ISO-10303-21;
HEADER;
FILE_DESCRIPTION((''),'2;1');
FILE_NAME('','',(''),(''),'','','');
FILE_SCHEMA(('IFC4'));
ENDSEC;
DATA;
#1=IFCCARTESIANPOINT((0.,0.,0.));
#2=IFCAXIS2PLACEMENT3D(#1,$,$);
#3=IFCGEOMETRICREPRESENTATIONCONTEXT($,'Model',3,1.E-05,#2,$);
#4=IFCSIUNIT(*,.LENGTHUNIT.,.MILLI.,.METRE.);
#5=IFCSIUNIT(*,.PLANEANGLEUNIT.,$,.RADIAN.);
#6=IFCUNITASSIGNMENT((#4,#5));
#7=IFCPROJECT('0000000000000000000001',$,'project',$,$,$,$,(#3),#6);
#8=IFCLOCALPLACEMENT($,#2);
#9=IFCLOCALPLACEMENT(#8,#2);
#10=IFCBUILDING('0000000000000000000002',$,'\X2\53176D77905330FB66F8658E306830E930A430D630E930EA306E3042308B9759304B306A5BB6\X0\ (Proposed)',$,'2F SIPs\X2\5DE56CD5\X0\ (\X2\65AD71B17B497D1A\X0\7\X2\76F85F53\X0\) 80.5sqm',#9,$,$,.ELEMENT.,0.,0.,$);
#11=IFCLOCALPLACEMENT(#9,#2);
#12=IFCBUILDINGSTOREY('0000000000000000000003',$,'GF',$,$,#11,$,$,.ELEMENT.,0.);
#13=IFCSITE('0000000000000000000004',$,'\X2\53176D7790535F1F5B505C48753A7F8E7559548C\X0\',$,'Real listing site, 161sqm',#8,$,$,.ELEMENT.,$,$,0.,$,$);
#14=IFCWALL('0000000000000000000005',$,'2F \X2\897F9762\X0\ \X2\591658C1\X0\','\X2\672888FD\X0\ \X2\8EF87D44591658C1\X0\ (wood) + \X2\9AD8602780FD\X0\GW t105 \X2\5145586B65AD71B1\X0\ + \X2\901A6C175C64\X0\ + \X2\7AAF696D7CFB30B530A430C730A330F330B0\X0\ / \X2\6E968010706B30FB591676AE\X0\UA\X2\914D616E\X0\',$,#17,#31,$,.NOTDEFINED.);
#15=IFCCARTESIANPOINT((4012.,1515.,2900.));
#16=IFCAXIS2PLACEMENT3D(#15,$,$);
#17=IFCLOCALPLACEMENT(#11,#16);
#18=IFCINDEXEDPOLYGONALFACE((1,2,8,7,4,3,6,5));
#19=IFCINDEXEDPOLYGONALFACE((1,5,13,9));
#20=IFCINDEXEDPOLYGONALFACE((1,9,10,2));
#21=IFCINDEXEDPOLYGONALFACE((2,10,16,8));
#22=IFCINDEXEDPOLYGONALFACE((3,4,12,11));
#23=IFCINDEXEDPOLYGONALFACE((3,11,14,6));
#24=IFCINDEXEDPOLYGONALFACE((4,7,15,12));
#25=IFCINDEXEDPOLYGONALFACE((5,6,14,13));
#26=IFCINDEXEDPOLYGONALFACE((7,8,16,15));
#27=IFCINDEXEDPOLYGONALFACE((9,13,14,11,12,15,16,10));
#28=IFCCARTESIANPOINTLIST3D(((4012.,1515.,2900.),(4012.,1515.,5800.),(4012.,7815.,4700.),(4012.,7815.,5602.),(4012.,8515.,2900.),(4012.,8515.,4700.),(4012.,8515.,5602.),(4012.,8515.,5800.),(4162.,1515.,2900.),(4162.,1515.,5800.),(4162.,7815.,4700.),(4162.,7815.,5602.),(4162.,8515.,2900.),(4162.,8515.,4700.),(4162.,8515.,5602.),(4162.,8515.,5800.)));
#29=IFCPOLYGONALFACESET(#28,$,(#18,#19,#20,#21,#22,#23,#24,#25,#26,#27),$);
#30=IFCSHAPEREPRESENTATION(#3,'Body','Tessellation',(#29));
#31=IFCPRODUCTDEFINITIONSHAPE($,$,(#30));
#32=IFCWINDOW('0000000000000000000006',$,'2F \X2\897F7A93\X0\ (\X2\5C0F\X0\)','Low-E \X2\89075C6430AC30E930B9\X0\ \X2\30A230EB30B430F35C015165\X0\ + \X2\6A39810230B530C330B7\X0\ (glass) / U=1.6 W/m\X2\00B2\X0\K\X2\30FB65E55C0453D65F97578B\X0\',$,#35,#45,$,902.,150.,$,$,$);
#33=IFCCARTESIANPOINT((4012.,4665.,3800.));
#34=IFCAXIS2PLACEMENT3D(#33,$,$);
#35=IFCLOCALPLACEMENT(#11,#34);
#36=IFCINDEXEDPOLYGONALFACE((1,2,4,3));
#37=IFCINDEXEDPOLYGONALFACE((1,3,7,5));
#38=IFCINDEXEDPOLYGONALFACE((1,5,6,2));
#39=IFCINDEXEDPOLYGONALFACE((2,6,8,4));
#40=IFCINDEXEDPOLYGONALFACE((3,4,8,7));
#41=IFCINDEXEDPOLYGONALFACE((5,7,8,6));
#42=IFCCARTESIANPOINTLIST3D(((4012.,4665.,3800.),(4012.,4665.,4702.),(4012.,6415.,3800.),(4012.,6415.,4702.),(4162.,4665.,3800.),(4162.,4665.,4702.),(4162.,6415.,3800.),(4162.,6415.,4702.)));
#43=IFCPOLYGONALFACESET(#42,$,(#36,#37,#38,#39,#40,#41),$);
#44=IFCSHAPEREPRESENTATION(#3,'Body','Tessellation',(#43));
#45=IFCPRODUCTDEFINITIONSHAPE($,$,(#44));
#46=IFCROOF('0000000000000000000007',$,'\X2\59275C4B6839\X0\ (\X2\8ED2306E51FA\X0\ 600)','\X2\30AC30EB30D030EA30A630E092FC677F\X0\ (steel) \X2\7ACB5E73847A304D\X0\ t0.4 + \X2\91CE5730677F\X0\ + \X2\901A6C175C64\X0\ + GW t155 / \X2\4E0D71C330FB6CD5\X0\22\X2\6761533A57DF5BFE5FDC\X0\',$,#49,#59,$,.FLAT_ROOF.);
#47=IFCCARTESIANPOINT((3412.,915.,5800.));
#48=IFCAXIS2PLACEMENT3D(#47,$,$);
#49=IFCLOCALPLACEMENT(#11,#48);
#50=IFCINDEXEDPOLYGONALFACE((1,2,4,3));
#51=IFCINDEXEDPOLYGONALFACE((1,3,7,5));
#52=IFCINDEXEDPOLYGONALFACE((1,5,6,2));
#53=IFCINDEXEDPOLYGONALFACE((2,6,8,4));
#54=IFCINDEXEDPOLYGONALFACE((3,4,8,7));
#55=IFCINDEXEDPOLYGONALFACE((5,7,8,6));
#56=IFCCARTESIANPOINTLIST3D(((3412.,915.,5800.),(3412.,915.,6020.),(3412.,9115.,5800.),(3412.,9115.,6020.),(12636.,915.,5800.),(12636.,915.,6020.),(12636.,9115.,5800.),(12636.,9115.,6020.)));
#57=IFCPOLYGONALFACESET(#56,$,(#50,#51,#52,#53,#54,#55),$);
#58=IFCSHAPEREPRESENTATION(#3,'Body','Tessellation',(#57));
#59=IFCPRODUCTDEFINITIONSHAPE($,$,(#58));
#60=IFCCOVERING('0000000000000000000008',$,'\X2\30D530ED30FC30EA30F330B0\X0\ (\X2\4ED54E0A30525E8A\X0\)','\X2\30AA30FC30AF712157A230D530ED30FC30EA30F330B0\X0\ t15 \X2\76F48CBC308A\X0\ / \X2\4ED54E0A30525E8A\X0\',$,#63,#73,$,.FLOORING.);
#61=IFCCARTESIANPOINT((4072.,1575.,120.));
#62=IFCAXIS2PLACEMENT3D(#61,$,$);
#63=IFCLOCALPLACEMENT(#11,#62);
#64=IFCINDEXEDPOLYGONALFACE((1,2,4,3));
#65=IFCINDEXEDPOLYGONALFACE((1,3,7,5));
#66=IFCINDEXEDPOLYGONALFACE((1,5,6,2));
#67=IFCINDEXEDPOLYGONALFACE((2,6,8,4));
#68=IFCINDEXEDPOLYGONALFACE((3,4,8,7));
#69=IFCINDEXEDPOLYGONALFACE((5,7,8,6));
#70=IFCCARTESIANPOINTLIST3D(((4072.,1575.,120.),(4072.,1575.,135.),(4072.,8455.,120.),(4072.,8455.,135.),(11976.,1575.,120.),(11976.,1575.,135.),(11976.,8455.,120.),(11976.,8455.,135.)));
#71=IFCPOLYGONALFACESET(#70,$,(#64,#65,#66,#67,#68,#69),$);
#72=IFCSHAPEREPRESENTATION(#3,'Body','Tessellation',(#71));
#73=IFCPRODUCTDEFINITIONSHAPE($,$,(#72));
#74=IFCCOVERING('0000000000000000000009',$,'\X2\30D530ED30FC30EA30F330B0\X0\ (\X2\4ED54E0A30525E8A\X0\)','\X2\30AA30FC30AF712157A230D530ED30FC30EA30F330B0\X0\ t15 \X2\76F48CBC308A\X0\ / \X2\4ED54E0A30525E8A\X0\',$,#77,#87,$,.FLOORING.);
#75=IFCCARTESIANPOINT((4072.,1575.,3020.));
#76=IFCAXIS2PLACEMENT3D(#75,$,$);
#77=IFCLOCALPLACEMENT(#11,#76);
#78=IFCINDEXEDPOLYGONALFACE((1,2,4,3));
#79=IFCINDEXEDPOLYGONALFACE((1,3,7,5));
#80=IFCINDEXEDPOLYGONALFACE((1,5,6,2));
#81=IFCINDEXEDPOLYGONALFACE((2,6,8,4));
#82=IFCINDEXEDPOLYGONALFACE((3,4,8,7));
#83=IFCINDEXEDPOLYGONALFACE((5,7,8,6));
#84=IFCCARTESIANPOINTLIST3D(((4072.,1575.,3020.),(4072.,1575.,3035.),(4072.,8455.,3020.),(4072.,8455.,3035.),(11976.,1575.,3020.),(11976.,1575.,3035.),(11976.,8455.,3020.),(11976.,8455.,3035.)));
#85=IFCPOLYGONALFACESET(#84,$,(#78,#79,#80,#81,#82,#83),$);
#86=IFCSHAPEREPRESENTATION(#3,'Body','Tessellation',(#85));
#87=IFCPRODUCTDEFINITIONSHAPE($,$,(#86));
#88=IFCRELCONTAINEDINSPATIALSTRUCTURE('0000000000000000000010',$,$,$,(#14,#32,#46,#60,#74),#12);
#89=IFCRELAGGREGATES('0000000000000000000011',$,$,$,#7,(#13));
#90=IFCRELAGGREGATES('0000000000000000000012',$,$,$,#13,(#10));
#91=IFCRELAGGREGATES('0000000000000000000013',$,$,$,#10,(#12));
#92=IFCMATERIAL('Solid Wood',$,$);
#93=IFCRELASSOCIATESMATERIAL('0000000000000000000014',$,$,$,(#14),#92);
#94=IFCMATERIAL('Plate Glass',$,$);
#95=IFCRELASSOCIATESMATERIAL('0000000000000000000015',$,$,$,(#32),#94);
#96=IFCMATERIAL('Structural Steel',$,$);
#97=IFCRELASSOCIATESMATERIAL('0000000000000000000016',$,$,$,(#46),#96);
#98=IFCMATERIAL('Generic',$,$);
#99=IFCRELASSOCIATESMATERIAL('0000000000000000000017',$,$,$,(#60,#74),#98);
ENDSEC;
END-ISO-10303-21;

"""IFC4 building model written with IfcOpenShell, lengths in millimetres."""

from ifc_helpers import new_model, si_unit, frame, frame_2d, origin, place, context, project, spatial, rectangle, extrude, material, element, fill, save


model = new_model("IFC4")

# Units and contexts
model_context = context("Model", 3, precision=1e-05, world=origin())
ifc_project = project(units=[si_unit("LENGTHUNIT", "METRE", prefix="MILLI"), si_unit("PLANEANGLEUNIT", "RADIAN")], contexts=[model_context])

# Site, building, storey
site_placement = place(None, origin())
site = spatial("IfcSite", under=ifc_project, at=site_placement, Name="北海道弟子屈町美留和", ObjectType="Real listing site, 161sqm", CompositionType="ELEMENT", RefElevation=0.0)
building_placement = place(site_placement, origin())
building = spatial("IfcBuilding", under=site, at=building_placement, Name="北海道・書斎とライブラリのある静かな家 (Proposed)", ObjectType="2F SIPs工法 (断熱等級7相当) 80.5sqm", CompositionType="ELEMENT", ElevationOfRefHeight=0.0, ElevationOfTerrain=0.0)
storey_placement = place(building_placement, origin())
storey = spatial("IfcBuildingStorey", under=building, at=storey_placement, Name="GF", CompositionType="ELEMENT", Elevation=0.0)

# Shared definitions
ifc_material_1 = material(Name="Solid Wood")

# Shared definitions
ifc_material_2 = material(Name="Plate Glass")

# Wall, opening, window
wall_1_placement = place(storey_placement, frame((4012.0, 1515.0, 2900.0)))
wall_1 = element("IfcWall", 1, at=wall_1_placement, inside=storey, material=ifc_material_1, Name="2F 西面 外壁", Description="木製 軸組外壁 (wood) + 高性能GW t105 充填断熱 + 通気層 + 窯業系サイディング / 準耐火・外皮UA配慮", PredefinedType="NOTDEFINED", context=model_context, shape_type="SweptSolid", body=[
    extrude(rectangle(XDim=150.0, YDim=7000.0, at=frame_2d((75.0, 3500.0))), frame((4012.0, 1515.0, 2900.0)), (0.0, 0.0, 1.0), 2900.0),
])
opening_1_placement = place(storey_placement, frame((4012.0, 4665.0, 3800.0)))
opening_1 = element("IfcOpeningElement", 2, at=opening_1_placement, cuts=wall_1, PredefinedType="NOTDEFINED", context=model_context, shape_type="SweptSolid", body=[
    extrude(rectangle(XDim=150.0, YDim=1750.0, at=frame_2d((75.0, 875.0))), frame((4012.0, 4665.0, 3800.0)), (0.0, 0.0, 1.0), 902.0),
])
window_1_placement = place(storey_placement, frame((4012.0, 4665.0, 3800.0)))
window_1 = element("IfcWindow", 3, at=window_1_placement, inside=storey, material=ifc_material_2, Name="2F 西窓 (小)", Description="Low-E 複層ガラス アルゴン封入 + 樹脂サッシ (glass) / U=1.6 W/m²K・日射取得型", OverallHeight=902.0, OverallWidth=150.0, context=model_context, shape_type="SweptSolid", body=[
    extrude(rectangle(XDim=150.0, YDim=1750.0, at=frame_2d((75.0, 875.0))), frame((4012.0, 4665.0, 3800.0)), (0.0, 0.0, 1.0), 902.0),
])
fill(opening_1, window_1)

# Roof
ifc_material_3 = material(Name="Structural Steel")
roof_placement = place(storey_placement, frame((3412.0, 915.0, 5800.0)))
element("IfcRoof", 4, at=roof_placement, inside=storey, material=ifc_material_3, Name="大屋根 (軒の出 600)", Description="ガルバリウム鋼板 (steel) 立平葺き t0.4 + 野地板 + 通気層 + GW t155 / 不燃・法22条区域対応", PredefinedType="FLAT_ROOF", context=model_context, shape_type="SweptSolid", body=[
    extrude(rectangle(XDim=9224.0, YDim=8200.0, at=frame_2d((4612.0, 4100.0))), frame((3412.0, 915.0, 5800.0)), (0.0, 0.0, 1.0), 220.0),
])

# Coverings
ifc_material_4 = material(Name="Generic")
covering_1_placement = place(storey_placement, frame((4072.0, 1575.0, 120.0)))
element("IfcCovering", 5, at=covering_1_placement, inside=storey, material=ifc_material_4, Name="フローリング (仕上げ床)", Description="オーク無垢フローリング t15 直貼り / 仕上げ床", PredefinedType="FLOORING", context=model_context, shape_type="SweptSolid", body=[
    extrude(rectangle(XDim=7904.0, YDim=6880.0, at=frame_2d((3952.0, 3440.0))), frame((4072.0, 1575.0, 120.0)), (0.0, 0.0, 1.0), 15.0),
])
covering_2_placement = place(storey_placement, frame((4072.0, 1575.0, 3020.0)))
element("IfcCovering", 6, at=covering_2_placement, inside=storey, material=ifc_material_4, Name="フローリング (仕上げ床)", Description="オーク無垢フローリング t15 直貼り / 仕上げ床", PredefinedType="FLOORING", context=model_context, shape_type="SweptSolid", body=[
    extrude(rectangle(XDim=7904.0, YDim=6880.0, at=frame_2d((3952.0, 3440.0))), frame((4072.0, 1575.0, 3020.0)), (0.0, 0.0, 1.0), 15.0),
])

save(model, "model.ifc")
